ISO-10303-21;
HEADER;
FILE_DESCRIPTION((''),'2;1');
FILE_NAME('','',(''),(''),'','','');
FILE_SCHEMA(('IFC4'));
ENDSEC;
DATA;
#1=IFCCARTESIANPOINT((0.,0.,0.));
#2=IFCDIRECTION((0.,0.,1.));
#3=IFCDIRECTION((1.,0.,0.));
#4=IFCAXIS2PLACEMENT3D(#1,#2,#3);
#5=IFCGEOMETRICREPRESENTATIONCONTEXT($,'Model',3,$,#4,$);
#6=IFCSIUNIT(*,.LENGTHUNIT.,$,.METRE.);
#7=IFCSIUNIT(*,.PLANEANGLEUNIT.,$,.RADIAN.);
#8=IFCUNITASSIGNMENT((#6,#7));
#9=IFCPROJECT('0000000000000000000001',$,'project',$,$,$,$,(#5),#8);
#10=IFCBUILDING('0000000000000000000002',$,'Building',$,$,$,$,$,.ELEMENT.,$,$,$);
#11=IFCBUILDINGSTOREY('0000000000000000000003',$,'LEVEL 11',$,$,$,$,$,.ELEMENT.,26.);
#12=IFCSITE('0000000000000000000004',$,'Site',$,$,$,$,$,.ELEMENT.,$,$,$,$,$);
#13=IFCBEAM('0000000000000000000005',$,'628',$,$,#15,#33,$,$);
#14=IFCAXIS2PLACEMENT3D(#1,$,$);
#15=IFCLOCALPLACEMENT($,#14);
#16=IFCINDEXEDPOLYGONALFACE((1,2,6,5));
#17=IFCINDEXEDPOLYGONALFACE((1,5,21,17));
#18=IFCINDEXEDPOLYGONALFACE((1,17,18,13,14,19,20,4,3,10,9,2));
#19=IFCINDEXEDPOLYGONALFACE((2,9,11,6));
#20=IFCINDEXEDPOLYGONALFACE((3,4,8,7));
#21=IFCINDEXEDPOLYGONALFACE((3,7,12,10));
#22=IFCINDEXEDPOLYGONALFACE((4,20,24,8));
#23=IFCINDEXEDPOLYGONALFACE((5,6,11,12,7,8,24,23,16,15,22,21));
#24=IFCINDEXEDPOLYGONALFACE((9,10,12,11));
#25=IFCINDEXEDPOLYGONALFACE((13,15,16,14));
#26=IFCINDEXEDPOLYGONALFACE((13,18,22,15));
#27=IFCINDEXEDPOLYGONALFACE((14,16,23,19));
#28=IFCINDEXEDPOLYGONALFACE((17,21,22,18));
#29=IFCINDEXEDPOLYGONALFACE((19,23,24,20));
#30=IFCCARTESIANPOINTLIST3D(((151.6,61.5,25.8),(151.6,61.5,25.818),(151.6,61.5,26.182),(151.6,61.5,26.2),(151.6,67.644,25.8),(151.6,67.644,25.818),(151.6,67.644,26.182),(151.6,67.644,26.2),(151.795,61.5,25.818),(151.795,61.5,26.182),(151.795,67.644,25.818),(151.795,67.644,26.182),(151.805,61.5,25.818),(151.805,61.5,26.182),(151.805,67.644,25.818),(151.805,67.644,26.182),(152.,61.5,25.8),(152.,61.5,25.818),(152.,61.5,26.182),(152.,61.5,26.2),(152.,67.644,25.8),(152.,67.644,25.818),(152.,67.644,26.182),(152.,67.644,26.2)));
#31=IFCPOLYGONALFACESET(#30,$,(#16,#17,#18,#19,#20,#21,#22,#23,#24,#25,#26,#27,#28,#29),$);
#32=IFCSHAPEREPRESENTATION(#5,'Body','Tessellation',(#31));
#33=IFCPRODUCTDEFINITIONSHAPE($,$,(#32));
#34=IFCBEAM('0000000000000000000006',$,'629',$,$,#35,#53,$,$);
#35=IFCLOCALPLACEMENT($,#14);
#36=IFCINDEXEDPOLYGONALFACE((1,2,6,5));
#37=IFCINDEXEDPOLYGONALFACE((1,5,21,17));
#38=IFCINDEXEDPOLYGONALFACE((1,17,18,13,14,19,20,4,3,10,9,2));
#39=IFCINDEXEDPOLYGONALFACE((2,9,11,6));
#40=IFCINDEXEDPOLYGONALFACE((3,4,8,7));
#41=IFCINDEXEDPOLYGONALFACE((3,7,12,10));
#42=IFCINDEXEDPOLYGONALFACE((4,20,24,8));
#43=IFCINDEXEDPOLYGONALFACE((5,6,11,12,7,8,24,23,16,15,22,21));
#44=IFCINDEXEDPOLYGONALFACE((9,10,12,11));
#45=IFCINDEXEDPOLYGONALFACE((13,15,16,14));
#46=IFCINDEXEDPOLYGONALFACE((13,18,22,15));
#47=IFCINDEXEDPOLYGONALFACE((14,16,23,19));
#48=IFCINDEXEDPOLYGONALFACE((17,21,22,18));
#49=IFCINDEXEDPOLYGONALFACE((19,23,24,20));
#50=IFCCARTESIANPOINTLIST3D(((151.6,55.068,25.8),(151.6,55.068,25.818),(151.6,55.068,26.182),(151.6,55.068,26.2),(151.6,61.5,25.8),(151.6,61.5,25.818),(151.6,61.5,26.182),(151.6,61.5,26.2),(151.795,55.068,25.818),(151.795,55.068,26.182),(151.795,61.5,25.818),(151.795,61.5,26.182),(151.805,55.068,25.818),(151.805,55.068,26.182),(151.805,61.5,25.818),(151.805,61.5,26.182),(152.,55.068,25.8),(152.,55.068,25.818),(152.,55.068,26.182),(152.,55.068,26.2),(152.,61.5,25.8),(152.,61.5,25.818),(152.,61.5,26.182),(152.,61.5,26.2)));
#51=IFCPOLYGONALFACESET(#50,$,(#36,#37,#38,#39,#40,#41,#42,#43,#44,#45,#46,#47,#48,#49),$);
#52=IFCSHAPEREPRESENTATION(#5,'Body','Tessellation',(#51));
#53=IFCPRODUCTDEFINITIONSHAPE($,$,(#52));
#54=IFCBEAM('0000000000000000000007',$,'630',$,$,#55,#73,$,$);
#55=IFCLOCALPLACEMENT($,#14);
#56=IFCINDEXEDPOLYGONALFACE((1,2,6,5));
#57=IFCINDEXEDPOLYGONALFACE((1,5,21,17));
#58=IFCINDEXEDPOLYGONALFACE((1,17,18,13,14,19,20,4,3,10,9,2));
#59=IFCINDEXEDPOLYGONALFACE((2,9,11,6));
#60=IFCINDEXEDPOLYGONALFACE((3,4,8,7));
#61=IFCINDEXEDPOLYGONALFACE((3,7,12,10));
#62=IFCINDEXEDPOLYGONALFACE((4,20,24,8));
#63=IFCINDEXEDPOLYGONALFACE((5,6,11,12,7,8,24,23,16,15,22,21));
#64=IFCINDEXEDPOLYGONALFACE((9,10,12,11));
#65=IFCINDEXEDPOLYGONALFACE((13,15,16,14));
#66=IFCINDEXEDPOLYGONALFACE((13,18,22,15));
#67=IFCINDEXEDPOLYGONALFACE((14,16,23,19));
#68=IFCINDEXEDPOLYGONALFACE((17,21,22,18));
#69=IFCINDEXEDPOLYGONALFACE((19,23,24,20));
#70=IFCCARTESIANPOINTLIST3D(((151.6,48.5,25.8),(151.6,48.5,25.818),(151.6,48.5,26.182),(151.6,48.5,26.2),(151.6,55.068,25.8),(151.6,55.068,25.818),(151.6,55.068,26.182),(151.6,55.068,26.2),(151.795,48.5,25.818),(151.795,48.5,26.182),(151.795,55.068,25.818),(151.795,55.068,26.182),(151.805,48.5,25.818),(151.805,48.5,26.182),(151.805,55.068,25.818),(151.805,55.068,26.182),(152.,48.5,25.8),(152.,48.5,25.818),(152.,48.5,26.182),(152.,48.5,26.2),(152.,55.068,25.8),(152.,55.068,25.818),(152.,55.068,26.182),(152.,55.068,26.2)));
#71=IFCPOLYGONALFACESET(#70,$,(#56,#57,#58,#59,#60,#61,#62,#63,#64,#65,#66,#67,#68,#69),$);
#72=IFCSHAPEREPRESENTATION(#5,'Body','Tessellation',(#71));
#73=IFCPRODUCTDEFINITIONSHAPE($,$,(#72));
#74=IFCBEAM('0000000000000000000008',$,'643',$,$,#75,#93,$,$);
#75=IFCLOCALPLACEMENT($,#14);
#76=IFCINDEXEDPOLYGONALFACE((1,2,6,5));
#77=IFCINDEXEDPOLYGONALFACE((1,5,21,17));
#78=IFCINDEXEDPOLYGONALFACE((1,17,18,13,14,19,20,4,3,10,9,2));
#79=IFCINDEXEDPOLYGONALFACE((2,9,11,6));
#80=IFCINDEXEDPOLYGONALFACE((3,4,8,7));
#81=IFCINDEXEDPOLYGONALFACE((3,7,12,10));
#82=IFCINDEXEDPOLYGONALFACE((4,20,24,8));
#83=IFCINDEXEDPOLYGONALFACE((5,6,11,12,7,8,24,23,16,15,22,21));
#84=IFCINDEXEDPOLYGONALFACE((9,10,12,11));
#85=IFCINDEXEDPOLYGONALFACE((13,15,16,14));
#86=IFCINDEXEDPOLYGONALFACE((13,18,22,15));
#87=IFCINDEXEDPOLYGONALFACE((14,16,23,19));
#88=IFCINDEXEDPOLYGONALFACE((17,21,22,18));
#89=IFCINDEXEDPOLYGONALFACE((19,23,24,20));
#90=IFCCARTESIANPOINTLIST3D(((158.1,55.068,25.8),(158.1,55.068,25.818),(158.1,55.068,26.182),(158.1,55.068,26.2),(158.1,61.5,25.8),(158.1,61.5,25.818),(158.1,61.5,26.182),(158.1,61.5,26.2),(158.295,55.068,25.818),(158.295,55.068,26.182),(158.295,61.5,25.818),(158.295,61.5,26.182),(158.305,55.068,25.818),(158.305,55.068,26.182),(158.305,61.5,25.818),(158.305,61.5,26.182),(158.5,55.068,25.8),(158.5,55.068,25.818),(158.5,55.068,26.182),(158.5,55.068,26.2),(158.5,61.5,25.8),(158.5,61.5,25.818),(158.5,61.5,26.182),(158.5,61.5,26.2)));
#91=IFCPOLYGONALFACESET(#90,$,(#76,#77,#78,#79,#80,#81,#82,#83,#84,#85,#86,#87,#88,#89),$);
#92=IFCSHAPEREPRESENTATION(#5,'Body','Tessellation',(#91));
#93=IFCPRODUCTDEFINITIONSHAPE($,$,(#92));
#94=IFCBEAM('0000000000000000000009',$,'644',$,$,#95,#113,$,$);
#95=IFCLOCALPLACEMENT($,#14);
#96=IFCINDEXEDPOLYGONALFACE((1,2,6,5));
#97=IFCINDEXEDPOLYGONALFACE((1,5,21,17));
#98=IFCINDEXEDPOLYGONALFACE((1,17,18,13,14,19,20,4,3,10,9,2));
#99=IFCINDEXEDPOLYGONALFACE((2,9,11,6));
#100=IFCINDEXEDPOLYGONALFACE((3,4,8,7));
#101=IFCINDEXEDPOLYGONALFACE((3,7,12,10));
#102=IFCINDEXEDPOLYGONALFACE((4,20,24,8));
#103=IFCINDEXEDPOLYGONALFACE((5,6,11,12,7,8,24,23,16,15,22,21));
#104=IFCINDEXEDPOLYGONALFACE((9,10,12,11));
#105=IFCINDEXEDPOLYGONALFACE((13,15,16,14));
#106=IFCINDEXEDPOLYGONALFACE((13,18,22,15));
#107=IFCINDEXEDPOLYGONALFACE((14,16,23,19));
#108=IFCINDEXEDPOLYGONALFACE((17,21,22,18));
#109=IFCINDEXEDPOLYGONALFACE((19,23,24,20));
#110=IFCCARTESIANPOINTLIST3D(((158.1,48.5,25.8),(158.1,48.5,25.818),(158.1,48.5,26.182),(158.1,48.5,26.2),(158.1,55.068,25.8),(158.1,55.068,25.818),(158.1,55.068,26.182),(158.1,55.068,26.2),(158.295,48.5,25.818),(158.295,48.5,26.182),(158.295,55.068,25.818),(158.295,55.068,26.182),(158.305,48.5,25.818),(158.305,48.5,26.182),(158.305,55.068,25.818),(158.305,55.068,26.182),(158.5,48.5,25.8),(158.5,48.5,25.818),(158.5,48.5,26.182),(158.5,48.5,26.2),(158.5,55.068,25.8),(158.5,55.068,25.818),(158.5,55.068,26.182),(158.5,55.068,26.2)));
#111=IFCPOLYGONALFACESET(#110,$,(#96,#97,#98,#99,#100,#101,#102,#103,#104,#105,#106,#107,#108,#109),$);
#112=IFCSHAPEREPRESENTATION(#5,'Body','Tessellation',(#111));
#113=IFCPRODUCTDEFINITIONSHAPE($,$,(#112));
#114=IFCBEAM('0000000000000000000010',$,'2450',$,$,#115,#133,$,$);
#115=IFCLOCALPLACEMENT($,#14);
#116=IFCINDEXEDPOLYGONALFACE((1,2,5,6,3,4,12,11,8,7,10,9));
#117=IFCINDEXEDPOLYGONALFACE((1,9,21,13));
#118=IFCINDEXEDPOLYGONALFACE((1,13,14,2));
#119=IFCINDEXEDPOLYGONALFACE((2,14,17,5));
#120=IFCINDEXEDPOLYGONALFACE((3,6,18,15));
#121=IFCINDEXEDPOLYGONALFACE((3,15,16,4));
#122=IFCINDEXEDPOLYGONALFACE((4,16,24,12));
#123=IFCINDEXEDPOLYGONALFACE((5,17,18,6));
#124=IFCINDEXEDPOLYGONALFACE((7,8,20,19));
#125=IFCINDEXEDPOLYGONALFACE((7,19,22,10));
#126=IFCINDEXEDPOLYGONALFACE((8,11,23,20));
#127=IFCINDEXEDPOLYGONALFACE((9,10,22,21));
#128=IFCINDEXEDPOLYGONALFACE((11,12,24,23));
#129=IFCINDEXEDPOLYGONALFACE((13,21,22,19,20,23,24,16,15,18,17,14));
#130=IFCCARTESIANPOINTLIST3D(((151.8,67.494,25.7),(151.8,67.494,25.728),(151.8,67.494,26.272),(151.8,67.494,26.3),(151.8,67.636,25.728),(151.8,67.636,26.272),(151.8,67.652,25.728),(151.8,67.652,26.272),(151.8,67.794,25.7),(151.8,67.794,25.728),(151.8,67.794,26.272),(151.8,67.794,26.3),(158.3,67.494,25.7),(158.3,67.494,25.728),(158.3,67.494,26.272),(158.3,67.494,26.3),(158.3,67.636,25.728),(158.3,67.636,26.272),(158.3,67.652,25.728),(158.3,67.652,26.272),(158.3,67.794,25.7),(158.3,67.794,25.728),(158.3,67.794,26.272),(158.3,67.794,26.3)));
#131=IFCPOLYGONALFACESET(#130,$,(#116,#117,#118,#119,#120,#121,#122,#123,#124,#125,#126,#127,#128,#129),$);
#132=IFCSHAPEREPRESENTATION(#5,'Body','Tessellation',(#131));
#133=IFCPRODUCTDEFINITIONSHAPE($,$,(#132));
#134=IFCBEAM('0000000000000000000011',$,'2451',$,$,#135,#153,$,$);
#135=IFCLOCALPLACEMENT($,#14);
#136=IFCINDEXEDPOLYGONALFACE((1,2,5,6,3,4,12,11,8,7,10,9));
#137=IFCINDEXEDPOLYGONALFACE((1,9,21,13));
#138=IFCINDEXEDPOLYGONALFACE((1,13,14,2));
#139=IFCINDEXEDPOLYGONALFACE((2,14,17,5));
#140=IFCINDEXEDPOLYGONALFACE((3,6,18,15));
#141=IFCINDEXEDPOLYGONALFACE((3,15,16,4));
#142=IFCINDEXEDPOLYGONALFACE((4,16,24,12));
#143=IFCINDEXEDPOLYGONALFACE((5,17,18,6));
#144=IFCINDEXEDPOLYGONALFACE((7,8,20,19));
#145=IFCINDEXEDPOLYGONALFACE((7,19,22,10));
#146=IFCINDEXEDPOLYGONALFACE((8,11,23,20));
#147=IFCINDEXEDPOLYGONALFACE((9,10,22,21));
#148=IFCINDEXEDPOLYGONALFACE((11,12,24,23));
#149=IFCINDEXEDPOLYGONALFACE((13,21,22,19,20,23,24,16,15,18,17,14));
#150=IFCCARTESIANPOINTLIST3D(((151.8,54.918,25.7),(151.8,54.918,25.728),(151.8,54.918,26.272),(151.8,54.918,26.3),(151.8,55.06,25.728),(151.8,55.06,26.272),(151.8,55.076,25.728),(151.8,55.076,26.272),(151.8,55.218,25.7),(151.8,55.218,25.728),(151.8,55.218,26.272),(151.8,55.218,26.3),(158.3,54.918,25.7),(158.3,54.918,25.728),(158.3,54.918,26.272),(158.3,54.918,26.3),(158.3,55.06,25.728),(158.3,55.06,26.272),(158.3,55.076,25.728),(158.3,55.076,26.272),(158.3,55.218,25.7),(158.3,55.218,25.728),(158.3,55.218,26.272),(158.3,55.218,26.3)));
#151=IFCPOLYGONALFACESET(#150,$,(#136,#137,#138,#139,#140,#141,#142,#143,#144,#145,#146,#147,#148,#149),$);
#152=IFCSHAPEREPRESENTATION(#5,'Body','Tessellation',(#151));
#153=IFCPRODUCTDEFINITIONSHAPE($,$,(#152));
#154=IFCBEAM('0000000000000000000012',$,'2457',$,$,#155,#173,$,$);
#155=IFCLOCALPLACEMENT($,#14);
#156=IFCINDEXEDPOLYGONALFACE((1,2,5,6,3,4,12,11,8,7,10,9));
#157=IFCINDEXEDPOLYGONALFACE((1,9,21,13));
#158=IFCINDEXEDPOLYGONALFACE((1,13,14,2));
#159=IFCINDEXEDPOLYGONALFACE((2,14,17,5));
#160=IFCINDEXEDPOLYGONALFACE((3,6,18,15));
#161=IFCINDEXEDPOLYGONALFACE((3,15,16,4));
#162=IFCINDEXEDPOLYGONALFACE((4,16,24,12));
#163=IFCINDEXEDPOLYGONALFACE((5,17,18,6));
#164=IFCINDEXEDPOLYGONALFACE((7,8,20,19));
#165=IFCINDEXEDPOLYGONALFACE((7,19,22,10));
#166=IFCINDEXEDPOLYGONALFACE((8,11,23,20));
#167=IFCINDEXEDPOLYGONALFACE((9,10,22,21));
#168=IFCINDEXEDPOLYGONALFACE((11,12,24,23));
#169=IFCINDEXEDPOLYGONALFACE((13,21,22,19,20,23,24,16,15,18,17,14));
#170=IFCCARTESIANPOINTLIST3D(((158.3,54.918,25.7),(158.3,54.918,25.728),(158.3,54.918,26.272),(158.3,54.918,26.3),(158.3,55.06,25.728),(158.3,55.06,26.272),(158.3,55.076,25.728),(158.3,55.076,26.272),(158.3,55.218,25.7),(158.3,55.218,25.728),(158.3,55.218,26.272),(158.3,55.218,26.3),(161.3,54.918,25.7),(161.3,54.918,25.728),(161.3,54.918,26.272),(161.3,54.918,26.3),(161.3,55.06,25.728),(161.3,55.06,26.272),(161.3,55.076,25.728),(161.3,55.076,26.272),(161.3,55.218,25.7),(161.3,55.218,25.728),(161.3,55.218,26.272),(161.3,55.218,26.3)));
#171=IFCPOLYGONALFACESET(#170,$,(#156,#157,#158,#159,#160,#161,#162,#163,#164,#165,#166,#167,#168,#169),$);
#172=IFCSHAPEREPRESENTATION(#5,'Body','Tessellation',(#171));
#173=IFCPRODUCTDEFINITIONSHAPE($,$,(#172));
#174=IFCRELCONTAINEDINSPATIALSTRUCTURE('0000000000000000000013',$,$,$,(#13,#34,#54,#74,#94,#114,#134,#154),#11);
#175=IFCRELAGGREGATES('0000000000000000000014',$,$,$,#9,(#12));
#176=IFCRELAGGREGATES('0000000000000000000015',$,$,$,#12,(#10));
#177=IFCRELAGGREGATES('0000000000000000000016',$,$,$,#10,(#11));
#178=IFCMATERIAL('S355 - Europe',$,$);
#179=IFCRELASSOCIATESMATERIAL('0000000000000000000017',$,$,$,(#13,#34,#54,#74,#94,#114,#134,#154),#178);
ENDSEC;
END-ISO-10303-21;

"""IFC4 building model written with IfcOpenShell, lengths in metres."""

from ifc_helpers import new_model, si_unit, frame, origin_with_axes, origin_2d_with_axis, place, context, project, spatial, i_section, extrude, material, material_profile, profile_set, profile_usage, element, save


model = new_model("IFC4")

# Units and contexts
model_context = context("Model", 3, world=origin_with_axes())
ifc_project = project(units=[si_unit("LENGTHUNIT", "METRE"), si_unit("PLANEANGLEUNIT", "RADIAN")], contexts=[model_context])

# Site, building, storey
site = spatial("IfcSite", under=ifc_project, Name="Site", CompositionType="ELEMENT")
building = spatial("IfcBuilding", under=site, Name="Building", CompositionType="ELEMENT")
storey = spatial("IfcBuildingStorey", under=building, Name="LEVEL 11", CompositionType="ELEMENT", Elevation=26.0)

# Shared definitions
ifc_material = material(Name="S355 - Europe")

# Beams
ifc_material_profile_1 = material_profile(ifc_material, i_section(OverallWidth=0.4, OverallDepth=0.4, WebThickness=0.01, FlangeThickness=0.018, at=origin_2d_with_axis()))
ifc_profile_set_1 = profile_set([ifc_material_profile_1])
ifc_profile_usage_1 = profile_usage(ifc_profile_set_1, cardinal=10)
beam_1_placement = place(None, frame((151.8, 67.644, 26.0), z_axis=(0.0, -1.0, 0.0), x_axis=(1.0, 0.0, 0.0)))
element("IfcBeam", 1, at=beam_1_placement, inside=storey, material=ifc_profile_usage_1, Name="628", context=model_context, shape_type="SweptSolid", body=[
    extrude(i_section(OverallWidth=0.4, OverallDepth=0.4, WebThickness=0.01, FlangeThickness=0.018, at=origin_2d_with_axis()), origin_with_axes(), (0.0, 0.0, 1.0), 6.144),
])
ifc_material_profile_2 = material_profile(ifc_material, i_section(OverallWidth=0.4, OverallDepth=0.4, WebThickness=0.01, FlangeThickness=0.018, at=origin_2d_with_axis()))
ifc_profile_set_2 = profile_set([ifc_material_profile_2])
ifc_profile_usage_2 = profile_usage(ifc_profile_set_2, cardinal=10)
beam_2_placement = place(None, frame((151.8, 61.5, 26.0), z_axis=(0.0, -1.0, 0.0), x_axis=(1.0, 0.0, 0.0)))
element("IfcBeam", 2, at=beam_2_placement, inside=storey, material=ifc_profile_usage_2, Name="629", context=model_context, shape_type="SweptSolid", body=[
    extrude(i_section(OverallWidth=0.4, OverallDepth=0.4, WebThickness=0.01, FlangeThickness=0.018, at=origin_2d_with_axis()), origin_with_axes(), (0.0, 0.0, 1.0), 6.432),
])
ifc_material_profile_3 = material_profile(ifc_material, i_section(OverallWidth=0.4, OverallDepth=0.4, WebThickness=0.01, FlangeThickness=0.018, at=origin_2d_with_axis()))
ifc_profile_set_3 = profile_set([ifc_material_profile_3])
ifc_profile_usage_3 = profile_usage(ifc_profile_set_3, cardinal=10)
beam_3_placement = place(None, frame((151.8, 55.068, 26.0), z_axis=(0.0, -1.0, 0.0), x_axis=(1.0, 0.0, 0.0)))
element("IfcBeam", 3, at=beam_3_placement, inside=storey, material=ifc_profile_usage_3, Name="630", context=model_context, shape_type="SweptSolid", body=[
    extrude(i_section(OverallWidth=0.4, OverallDepth=0.4, WebThickness=0.01, FlangeThickness=0.018, at=origin_2d_with_axis()), origin_with_axes(), (0.0, 0.0, 1.0), 6.568),
])
ifc_material_profile_4 = material_profile(ifc_material, i_section(OverallWidth=0.4, OverallDepth=0.4, WebThickness=0.01, FlangeThickness=0.018, at=origin_2d_with_axis()))
ifc_profile_set_4 = profile_set([ifc_material_profile_4])
ifc_profile_usage_4 = profile_usage(ifc_profile_set_4, cardinal=10)
beam_4_placement = place(None, frame((158.3, 61.5, 26.0), z_axis=(0.0, -1.0, 0.0), x_axis=(1.0, 0.0, 0.0)))
element("IfcBeam", 4, at=beam_4_placement, inside=storey, material=ifc_profile_usage_4, Name="643", context=model_context, shape_type="SweptSolid", body=[
    extrude(i_section(OverallWidth=0.4, OverallDepth=0.4, WebThickness=0.01, FlangeThickness=0.018, at=origin_2d_with_axis()), origin_with_axes(), (0.0, 0.0, 1.0), 6.432),
])
ifc_material_profile_5 = material_profile(ifc_material, i_section(OverallWidth=0.4, OverallDepth=0.4, WebThickness=0.01, FlangeThickness=0.018, at=origin_2d_with_axis()))
ifc_profile_set_5 = profile_set([ifc_material_profile_5])
ifc_profile_usage_5 = profile_usage(ifc_profile_set_5, cardinal=10)
beam_5_placement = place(None, frame((158.3, 55.068, 26.0), z_axis=(0.0, -1.0, 0.0), x_axis=(1.0, 0.0, 0.0)))
element("IfcBeam", 5, at=beam_5_placement, inside=storey, material=ifc_profile_usage_5, Name="644", context=model_context, shape_type="SweptSolid", body=[
    extrude(i_section(OverallWidth=0.4, OverallDepth=0.4, WebThickness=0.01, FlangeThickness=0.018, at=origin_2d_with_axis()), origin_with_axes(), (0.0, 0.0, 1.0), 6.568),
])
ifc_material_profile_6 = material_profile(ifc_material, i_section(OverallWidth=0.3, OverallDepth=0.6, WebThickness=0.016, FlangeThickness=0.028, at=origin_2d_with_axis()))
ifc_profile_set_6 = profile_set([ifc_material_profile_6])
ifc_profile_usage_6 = profile_usage(ifc_profile_set_6, cardinal=10)
beam_6_placement = place(None, frame((151.8, 67.644, 26.0), z_axis=(1.0, 0.0, 0.0), x_axis=(0.0, 1.0, 0.0)))
element("IfcBeam", 6, at=beam_6_placement, inside=storey, material=ifc_profile_usage_6, Name="2450", context=model_context, shape_type="SweptSolid", body=[
    extrude(i_section(OverallWidth=0.3, OverallDepth=0.6, WebThickness=0.016, FlangeThickness=0.028, at=origin_2d_with_axis()), origin_with_axes(), (0.0, 0.0, 1.0), 6.5),
])
ifc_material_profile_7 = material_profile(ifc_material, i_section(OverallWidth=0.3, OverallDepth=0.6, WebThickness=0.016, FlangeThickness=0.028, at=origin_2d_with_axis()))
ifc_profile_set_7 = profile_set([ifc_material_profile_7])
ifc_profile_usage_7 = profile_usage(ifc_profile_set_7, cardinal=10)
beam_7_placement = place(None, frame((151.8, 55.068, 26.0), z_axis=(1.0, 0.0, 0.0), x_axis=(0.0, 1.0, 0.0)))
element("IfcBeam", 7, at=beam_7_placement, inside=storey, material=ifc_profile_usage_7, Name="2451", context=model_context, shape_type="SweptSolid", body=[
    extrude(i_section(OverallWidth=0.3, OverallDepth=0.6, WebThickness=0.016, FlangeThickness=0.028, at=origin_2d_with_axis()), origin_with_axes(), (0.0, 0.0, 1.0), 6.5),
])
ifc_material_profile_8 = material_profile(ifc_material, i_section(OverallWidth=0.3, OverallDepth=0.6, WebThickness=0.016, FlangeThickness=0.028, at=origin_2d_with_axis()))
ifc_profile_set_8 = profile_set([ifc_material_profile_8])
ifc_profile_usage_8 = profile_usage(ifc_profile_set_8, cardinal=10)
beam_8_placement = place(None, frame((158.3, 55.068, 26.0), z_axis=(1.0, 0.0, 0.0), x_axis=(0.0, 1.0, 0.0)))
element("IfcBeam", 8, at=beam_8_placement, inside=storey, material=ifc_profile_usage_8, Name="2457", context=model_context, shape_type="SweptSolid", body=[
    extrude(i_section(OverallWidth=0.3, OverallDepth=0.6, WebThickness=0.016, FlangeThickness=0.028, at=origin_2d_with_axis()), origin_with_axes(), (0.0, 0.0, 1.0), 3.0),
])

save(model, "model.ifc")
